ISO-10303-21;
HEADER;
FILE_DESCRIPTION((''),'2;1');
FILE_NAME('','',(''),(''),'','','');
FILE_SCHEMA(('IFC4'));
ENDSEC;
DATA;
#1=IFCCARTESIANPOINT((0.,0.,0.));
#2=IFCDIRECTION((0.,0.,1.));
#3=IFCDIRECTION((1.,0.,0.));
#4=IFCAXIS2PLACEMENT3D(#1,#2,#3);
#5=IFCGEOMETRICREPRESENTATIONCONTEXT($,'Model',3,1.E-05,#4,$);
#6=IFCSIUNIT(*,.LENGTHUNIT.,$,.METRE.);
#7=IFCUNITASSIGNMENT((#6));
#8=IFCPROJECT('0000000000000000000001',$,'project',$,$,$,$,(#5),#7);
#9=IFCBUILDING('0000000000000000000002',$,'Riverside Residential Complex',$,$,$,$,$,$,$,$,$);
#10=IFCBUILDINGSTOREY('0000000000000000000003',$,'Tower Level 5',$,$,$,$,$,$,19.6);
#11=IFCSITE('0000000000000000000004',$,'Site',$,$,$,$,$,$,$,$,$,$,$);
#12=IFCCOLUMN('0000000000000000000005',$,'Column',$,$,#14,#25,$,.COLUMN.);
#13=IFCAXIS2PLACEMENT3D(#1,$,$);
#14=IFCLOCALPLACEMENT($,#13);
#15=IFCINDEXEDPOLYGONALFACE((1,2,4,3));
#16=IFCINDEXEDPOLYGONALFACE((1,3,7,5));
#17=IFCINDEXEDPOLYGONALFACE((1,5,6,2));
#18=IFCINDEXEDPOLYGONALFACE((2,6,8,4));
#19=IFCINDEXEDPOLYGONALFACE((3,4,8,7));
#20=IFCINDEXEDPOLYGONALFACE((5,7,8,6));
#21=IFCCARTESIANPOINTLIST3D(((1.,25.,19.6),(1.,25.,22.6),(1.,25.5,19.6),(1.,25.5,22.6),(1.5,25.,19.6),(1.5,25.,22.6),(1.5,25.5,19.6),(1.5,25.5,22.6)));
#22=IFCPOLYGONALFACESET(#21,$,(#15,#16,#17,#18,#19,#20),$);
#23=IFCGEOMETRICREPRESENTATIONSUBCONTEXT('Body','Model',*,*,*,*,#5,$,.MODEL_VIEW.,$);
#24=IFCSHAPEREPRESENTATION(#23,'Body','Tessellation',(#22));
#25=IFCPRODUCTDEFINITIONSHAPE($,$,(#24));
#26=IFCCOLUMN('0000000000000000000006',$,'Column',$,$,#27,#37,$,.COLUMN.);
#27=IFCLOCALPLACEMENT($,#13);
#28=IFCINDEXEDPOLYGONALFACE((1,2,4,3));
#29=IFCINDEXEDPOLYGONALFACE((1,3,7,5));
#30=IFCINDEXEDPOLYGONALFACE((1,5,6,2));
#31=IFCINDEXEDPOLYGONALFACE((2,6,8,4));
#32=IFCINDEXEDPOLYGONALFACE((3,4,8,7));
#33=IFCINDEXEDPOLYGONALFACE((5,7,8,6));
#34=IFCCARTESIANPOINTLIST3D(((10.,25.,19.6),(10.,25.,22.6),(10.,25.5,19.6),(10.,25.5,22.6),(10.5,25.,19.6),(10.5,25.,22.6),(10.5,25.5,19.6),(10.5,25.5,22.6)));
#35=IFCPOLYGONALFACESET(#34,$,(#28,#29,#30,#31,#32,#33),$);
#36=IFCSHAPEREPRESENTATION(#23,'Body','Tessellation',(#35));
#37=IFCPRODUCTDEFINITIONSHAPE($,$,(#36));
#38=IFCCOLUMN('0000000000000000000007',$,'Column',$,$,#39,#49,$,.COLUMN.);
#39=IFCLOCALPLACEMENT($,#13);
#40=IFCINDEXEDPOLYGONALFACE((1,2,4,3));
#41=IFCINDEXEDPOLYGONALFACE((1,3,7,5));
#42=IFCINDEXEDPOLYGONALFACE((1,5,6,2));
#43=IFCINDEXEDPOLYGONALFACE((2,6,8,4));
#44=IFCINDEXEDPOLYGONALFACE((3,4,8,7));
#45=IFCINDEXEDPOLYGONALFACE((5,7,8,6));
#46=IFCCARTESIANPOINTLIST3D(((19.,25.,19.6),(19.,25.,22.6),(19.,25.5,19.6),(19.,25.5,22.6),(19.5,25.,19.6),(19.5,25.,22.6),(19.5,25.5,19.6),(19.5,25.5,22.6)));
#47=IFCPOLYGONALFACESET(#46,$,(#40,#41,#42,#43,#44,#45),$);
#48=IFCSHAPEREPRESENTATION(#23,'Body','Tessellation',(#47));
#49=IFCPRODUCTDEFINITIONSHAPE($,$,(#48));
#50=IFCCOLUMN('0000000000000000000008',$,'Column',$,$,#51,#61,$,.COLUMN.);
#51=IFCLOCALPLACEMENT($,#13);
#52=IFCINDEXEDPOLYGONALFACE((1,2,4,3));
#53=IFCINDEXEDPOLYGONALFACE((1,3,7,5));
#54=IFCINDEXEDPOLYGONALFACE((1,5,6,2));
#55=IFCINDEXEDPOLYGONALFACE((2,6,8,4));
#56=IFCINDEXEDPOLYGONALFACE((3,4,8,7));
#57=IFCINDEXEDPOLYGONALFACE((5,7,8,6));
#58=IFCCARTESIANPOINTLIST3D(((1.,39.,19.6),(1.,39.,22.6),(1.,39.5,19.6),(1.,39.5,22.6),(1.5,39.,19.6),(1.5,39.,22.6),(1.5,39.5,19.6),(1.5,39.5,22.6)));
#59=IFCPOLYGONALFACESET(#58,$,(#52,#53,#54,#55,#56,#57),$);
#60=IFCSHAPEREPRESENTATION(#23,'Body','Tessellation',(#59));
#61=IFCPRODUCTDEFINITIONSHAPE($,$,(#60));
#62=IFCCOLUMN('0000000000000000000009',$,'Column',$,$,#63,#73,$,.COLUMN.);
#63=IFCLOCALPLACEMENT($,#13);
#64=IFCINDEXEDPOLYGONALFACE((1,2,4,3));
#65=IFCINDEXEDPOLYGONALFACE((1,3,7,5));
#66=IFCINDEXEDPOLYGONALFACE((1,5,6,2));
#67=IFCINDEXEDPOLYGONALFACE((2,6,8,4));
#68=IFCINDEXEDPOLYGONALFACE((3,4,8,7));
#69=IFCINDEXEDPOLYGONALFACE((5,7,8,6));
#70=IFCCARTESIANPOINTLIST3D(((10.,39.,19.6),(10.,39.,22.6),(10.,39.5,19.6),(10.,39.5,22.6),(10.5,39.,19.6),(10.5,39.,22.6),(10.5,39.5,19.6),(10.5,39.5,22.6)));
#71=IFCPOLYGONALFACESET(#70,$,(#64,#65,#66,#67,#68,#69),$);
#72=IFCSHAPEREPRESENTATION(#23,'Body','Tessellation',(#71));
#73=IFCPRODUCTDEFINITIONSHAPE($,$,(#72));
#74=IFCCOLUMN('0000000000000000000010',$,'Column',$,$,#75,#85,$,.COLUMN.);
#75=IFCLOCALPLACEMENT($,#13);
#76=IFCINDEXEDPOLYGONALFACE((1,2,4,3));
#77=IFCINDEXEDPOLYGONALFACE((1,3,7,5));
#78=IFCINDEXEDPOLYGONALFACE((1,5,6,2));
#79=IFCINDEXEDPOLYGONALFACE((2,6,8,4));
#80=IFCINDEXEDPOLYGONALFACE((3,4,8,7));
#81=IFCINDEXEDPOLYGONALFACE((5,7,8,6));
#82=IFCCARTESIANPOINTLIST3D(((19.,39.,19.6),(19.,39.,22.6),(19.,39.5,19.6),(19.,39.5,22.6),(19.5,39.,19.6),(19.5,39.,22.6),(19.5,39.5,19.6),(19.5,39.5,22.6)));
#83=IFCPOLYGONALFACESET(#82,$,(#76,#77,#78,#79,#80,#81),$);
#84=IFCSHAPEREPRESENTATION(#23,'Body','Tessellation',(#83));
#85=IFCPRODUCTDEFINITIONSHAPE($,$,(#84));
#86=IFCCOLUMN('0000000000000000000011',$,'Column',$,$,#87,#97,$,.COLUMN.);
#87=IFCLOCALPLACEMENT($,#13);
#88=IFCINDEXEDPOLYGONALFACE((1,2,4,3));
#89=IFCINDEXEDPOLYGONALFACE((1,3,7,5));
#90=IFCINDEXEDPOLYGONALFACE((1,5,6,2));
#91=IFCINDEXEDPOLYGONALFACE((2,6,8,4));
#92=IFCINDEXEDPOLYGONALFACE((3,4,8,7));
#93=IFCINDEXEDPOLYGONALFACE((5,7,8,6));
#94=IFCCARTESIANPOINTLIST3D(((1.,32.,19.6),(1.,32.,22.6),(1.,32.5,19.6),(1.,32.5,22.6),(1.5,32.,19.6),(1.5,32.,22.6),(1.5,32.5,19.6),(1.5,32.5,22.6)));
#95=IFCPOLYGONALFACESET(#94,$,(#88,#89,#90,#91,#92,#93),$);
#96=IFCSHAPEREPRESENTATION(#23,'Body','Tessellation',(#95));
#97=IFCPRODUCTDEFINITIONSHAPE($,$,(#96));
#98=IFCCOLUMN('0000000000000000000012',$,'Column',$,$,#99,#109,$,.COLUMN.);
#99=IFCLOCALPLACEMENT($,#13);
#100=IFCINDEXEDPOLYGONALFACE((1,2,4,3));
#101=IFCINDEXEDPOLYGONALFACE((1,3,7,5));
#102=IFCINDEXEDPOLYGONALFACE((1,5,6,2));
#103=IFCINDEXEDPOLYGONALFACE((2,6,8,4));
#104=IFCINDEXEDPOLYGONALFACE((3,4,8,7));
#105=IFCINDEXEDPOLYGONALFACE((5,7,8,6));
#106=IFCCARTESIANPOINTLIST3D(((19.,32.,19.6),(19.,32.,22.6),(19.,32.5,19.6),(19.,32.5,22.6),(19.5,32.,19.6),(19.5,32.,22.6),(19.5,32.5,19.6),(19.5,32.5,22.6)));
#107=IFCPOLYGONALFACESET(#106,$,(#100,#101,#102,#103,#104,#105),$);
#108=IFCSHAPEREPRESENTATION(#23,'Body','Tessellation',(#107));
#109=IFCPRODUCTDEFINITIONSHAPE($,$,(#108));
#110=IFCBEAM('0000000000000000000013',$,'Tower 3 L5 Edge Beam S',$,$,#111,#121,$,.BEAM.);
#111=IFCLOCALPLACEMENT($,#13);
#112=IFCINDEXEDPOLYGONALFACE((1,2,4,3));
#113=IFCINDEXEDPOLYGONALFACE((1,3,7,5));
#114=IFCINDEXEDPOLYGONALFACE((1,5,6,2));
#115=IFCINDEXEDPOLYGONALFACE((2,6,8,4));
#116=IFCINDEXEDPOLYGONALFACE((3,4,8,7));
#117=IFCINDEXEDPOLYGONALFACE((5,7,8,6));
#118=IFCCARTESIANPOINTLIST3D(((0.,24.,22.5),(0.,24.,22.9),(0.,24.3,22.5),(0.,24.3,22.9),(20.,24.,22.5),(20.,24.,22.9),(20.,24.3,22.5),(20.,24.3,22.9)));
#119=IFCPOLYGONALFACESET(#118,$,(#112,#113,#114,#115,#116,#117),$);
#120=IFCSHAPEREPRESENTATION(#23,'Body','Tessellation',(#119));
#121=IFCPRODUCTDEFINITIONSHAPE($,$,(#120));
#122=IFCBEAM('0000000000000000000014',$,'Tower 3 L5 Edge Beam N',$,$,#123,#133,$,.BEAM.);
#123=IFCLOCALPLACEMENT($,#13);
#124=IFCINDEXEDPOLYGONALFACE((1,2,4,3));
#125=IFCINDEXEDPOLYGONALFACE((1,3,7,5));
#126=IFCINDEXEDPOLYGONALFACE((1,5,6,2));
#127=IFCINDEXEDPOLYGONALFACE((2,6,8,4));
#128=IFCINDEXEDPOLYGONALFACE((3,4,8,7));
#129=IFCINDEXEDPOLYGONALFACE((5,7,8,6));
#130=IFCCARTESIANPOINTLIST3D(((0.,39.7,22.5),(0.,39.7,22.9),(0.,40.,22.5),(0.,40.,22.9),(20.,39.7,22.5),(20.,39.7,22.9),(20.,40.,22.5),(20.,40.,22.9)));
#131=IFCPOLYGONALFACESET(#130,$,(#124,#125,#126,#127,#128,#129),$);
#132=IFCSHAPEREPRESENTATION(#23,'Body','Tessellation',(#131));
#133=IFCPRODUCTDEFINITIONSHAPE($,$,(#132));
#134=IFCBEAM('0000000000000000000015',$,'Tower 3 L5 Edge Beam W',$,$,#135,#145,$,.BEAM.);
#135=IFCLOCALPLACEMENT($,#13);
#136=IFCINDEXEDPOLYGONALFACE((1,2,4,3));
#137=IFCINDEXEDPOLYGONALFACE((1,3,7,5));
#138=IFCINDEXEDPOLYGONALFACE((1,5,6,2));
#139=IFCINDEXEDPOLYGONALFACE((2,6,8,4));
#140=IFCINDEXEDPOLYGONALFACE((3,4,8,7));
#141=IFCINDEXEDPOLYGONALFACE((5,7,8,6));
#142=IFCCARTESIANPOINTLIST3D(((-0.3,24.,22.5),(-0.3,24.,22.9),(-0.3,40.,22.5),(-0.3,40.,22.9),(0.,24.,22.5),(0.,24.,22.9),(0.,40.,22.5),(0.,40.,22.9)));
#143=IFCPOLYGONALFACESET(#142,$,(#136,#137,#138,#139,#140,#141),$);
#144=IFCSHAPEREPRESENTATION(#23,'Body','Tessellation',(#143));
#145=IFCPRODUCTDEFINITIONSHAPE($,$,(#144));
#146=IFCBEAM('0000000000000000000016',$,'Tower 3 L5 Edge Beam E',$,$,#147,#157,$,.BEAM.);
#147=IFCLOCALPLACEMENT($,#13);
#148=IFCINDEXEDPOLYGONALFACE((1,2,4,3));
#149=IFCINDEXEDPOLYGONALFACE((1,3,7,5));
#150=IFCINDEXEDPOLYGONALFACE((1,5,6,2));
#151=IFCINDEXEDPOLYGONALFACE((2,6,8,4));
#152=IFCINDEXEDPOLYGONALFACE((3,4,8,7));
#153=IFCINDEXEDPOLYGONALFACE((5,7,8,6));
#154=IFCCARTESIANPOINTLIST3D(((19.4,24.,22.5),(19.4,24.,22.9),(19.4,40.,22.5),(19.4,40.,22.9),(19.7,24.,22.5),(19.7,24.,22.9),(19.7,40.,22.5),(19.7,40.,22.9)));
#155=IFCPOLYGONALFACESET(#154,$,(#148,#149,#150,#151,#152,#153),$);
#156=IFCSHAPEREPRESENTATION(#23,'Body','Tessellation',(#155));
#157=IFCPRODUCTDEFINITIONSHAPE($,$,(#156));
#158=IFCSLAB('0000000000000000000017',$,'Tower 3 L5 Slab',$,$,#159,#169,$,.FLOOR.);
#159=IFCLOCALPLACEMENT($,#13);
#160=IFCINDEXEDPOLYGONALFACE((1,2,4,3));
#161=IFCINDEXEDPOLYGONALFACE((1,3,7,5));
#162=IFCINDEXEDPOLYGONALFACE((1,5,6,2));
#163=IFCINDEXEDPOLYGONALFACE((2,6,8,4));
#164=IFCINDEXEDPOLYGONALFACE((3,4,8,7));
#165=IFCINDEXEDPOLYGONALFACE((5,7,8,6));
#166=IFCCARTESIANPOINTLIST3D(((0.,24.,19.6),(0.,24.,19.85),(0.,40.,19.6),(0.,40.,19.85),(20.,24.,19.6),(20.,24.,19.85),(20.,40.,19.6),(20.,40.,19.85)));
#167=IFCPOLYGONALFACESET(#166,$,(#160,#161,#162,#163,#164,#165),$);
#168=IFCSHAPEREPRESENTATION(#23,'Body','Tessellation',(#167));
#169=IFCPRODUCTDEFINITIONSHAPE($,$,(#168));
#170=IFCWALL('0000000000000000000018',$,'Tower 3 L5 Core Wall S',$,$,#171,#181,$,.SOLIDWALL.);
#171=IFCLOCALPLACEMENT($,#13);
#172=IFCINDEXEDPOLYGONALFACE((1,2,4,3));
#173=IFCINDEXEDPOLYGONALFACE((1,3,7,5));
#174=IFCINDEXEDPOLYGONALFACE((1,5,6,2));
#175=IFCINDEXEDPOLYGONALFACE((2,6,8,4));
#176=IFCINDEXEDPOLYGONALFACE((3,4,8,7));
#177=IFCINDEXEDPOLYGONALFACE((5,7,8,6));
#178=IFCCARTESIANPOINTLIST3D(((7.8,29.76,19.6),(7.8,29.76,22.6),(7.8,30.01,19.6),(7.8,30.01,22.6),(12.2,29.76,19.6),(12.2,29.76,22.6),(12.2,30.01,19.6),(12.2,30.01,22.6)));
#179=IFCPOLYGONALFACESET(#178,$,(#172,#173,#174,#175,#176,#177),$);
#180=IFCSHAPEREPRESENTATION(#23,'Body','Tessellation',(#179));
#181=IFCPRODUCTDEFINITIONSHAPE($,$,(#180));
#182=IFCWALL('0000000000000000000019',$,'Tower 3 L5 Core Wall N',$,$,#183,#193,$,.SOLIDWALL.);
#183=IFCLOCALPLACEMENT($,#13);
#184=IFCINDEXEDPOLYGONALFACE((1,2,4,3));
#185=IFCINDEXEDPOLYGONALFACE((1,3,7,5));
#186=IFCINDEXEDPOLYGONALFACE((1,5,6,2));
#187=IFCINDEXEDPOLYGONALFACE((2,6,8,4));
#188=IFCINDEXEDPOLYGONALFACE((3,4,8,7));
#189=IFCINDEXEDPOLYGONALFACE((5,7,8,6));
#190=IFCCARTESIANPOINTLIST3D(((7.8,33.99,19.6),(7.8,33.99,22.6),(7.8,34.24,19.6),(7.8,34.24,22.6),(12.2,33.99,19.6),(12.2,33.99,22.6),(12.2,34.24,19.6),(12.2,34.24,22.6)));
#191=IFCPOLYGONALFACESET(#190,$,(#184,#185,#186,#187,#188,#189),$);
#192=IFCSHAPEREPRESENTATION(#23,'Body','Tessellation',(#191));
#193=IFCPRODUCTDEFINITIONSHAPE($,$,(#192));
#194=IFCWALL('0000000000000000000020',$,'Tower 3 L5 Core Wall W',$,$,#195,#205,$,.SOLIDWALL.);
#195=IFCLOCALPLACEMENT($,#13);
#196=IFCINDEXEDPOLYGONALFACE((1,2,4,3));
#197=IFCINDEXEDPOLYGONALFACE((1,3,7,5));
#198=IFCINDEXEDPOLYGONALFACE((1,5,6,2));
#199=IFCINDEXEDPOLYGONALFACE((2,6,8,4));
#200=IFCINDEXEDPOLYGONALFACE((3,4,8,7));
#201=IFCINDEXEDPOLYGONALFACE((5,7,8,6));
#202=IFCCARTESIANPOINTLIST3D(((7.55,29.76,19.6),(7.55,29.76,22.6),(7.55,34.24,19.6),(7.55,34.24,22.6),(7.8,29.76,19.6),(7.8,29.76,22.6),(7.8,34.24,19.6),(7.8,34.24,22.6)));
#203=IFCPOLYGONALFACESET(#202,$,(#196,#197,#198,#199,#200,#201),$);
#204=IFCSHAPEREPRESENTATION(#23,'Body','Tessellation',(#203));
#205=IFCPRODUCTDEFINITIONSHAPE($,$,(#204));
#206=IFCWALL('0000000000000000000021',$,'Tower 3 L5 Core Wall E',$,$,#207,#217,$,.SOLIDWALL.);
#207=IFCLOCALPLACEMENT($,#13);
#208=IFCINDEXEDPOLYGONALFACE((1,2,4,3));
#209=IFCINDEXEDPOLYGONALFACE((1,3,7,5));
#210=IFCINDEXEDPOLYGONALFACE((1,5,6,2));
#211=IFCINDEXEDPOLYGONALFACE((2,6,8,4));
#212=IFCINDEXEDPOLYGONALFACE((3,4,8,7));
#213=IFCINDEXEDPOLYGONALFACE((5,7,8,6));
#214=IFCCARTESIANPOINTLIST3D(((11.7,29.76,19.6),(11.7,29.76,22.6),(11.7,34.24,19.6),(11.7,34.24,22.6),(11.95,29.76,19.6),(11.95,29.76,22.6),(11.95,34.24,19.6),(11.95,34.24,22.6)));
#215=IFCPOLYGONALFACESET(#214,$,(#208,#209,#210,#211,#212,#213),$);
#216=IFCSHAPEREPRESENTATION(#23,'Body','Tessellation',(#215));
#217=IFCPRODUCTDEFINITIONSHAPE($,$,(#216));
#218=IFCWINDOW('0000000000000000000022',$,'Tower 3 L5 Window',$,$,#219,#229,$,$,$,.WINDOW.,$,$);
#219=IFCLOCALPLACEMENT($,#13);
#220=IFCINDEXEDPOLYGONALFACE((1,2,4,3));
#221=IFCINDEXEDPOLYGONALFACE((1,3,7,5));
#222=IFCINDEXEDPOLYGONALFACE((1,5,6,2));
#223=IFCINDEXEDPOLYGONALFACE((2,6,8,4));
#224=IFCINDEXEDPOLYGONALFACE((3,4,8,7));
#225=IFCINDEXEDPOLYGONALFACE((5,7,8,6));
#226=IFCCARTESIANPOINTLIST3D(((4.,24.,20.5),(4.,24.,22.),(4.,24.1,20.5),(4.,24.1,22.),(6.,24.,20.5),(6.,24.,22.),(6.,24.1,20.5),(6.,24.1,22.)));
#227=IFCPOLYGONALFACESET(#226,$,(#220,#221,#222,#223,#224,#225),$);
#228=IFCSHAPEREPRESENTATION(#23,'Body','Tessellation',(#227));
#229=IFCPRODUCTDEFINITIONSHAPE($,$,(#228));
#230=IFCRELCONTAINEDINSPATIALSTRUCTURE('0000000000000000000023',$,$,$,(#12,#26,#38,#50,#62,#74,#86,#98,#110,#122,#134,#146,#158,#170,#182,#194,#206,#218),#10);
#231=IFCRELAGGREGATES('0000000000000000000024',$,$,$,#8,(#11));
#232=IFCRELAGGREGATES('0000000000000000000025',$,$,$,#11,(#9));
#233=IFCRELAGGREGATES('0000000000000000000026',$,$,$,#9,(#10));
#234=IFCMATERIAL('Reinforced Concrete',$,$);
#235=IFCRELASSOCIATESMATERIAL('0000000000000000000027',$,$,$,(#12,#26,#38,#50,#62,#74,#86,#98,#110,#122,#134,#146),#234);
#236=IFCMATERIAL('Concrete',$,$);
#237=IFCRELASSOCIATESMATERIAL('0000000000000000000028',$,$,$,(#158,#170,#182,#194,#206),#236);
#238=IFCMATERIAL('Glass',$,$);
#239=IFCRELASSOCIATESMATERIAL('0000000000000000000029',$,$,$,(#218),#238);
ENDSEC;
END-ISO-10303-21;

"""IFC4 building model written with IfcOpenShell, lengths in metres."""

from ifc_helpers import new_model, si_unit, frame, origin_with_axes, place, context, subcontext, project, spatial, line, indexed_curve, outline, extrude, material, element, save


model = new_model("IFC4")

# Units and contexts
model_context = context("Model", 3, precision=1e-05, world=origin_with_axes())
body_context = subcontext(model_context, "Body", "Model", "MODEL_VIEW")
ifc_project = project(units=[si_unit("LENGTHUNIT", "METRE")], contexts=[model_context])

# Site, building, storey
site = spatial("IfcSite", under=ifc_project, Name="Site")
building = spatial("IfcBuilding", under=site, Name="Riverside Residential Complex")
storey = spatial("IfcBuildingStorey", under=building, Name="Tower Level 5", Elevation=19.6)

# Columns
ifc_material_1 = material(Name="Reinforced Concrete")
for number, where, z_axis, x_axis, name in (
    (1, (1.0, 25.0, 19.6), (0.0, 0.0, 1.0), (1.0, 0.0, 0.0), "Column"),
    (2, (10.0, 25.0, 19.6), (0.0, 0.0, 1.0), (1.0, 0.0, 0.0), "Column"),
    (3, (19.0, 25.0, 19.6), (0.0, 0.0, 1.0), (1.0, 0.0, 0.0), "Column"),
    (4, (1.0, 39.0, 19.6), (0.0, 0.0, 1.0), (1.0, 0.0, 0.0), "Column"),
    (5, (10.0, 39.0, 19.6), (0.0, 0.0, 1.0), (1.0, 0.0, 0.0), "Column"),
    (6, (19.0, 39.0, 19.6), (0.0, 0.0, 1.0), (1.0, 0.0, 0.0), "Column"),
    (7, (1.0, 32.0, 19.6), (0.0, 0.0, 1.0), (1.0, 0.0, 0.0), "Column"),
    (8, (19.0, 32.0, 19.6), (0.0, 0.0, 1.0), (1.0, 0.0, 0.0), "Column"),
):
    element("IfcColumn", number, at=place(None, frame(where, z_axis=z_axis, x_axis=x_axis)), inside=storey, material=ifc_material_1, Name=name, PredefinedType="COLUMN", context=body_context, shape_type="SweptSolid", body=[
        extrude(outline(indexed_curve([(0.0, 0.0), (0.5, 0.0), (0.5, 0.5), (0.0, 0.5)], segments=[line(1, 2, 3, 4, 1)])), origin_with_axes(), (0.0, 0.0, 1.0), 3.0),
    ])

# Beams
for number, where, z_axis, x_axis, name in (
    (9, (0.0, 24.0, 22.5), (0.0, 0.0, 1.0), (1.0, 0.0, 0.0), "Tower 3 L5 Edge Beam S"),
    (10, (0.0, 39.7, 22.5), (0.0, 0.0, 1.0), (1.0, 0.0, 0.0), "Tower 3 L5 Edge Beam N"),
):
    element("IfcBeam", number, at=place(None, frame(where, z_axis=z_axis, x_axis=x_axis)), inside=storey, material=ifc_material_1, Name=name, PredefinedType="BEAM", context=body_context, shape_type="SweptSolid", body=[
        extrude(outline(indexed_curve([(0.0, 0.0), (20.0, 0.0), (20.0, 0.3), (0.0, 0.3)], segments=[line(1, 2, 3, 4, 1)])), origin_with_axes(), (0.0, 0.0, 1.0), 0.4),
    ])
for number, where, z_axis, x_axis, name in (
    (11, (0.0, 24.0, 22.5), (0.0, 0.0, 1.0), (0.0, 1.0, 0.0), "Tower 3 L5 Edge Beam W"),
    (12, (19.7, 24.0, 22.5), (0.0, 0.0, 1.0), (0.0, 1.0, 0.0), "Tower 3 L5 Edge Beam E"),
):
    element("IfcBeam", number, at=place(None, frame(where, z_axis=z_axis, x_axis=x_axis)), inside=storey, material=ifc_material_1, Name=name, PredefinedType="BEAM", context=body_context, shape_type="SweptSolid", body=[
        extrude(outline(indexed_curve([(0.0, 0.0), (16.0, 0.0), (16.0, 0.3), (0.0, 0.3)], segments=[line(1, 2, 3, 4, 1)])), origin_with_axes(), (0.0, 0.0, 1.0), 0.4),
    ])

# Slab
ifc_material_2 = material(Name="Concrete")
slab_placement = place(None, frame((0.0, 24.0, 19.6), z_axis=(0.0, 0.0, 1.0), x_axis=(1.0, 0.0, 0.0)))
element("IfcSlab", 13, at=slab_placement, inside=storey, material=ifc_material_2, Name="Tower 3 L5 Slab", PredefinedType="FLOOR", context=body_context, shape_type="SweptSolid", body=[
    extrude(outline(indexed_curve([(0.0, 0.0), (20.0, 0.0), (20.0, 16.0), (0.0, 16.0)], segments=[line(1, 2, 3, 4, 1)])), origin_with_axes(), (0.0, 0.0, 1.0), 0.25),
])

# Walls
for number, where, z_axis, x_axis, name in (
    (14, (7.8, 29.76, 19.6), (0.0, 0.0, 1.0), (1.0, 0.0, 0.0), "Tower 3 L5 Core Wall S"),
    (15, (7.8, 33.99, 19.6), (0.0, 0.0, 1.0), (1.0, 0.0, 0.0), "Tower 3 L5 Core Wall N"),
):
    element("IfcWall", number, at=place(None, frame(where, z_axis=z_axis, x_axis=x_axis)), inside=storey, material=ifc_material_2, Name=name, PredefinedType="SOLIDWALL", context=body_context, shape_type="SweptSolid", body=[
        extrude(outline(indexed_curve([(0.0, 0.0), (4.4, 0.0), (4.4, 0.25), (0.0, 0.25)], segments=[line(1, 2, 3, 4, 1)])), origin_with_axes(), (0.0, 0.0, 1.0), 3.0),
    ])
for number, where, z_axis, x_axis, name in (
    (16, (7.8, 29.76, 19.6), (0.0, 0.0, 1.0), (0.0, 1.0, 0.0), "Tower 3 L5 Core Wall W"),
    (17, (11.95, 29.76, 19.6), (0.0, 0.0, 1.0), (0.0, 1.0, 0.0), "Tower 3 L5 Core Wall E"),
):
    element("IfcWall", number, at=place(None, frame(where, z_axis=z_axis, x_axis=x_axis)), inside=storey, material=ifc_material_2, Name=name, PredefinedType="SOLIDWALL", context=body_context, shape_type="SweptSolid", body=[
        extrude(outline(indexed_curve([(0.0, 0.0), (4.48, 0.0), (4.48, 0.25), (0.0, 0.25)], segments=[line(1, 2, 3, 4, 1)])), origin_with_axes(), (0.0, 0.0, 1.0), 3.0),
    ])

# Window
ifc_material_3 = material(Name="Glass")
for number, where, z_axis, x_axis, name in (
    (18, (4.0, 24.0, 20.5), (0.0, 0.0, 1.0), (1.0, 0.0, 0.0), "Tower 3 L5 Window"),
):
    element("IfcWindow", number, at=place(None, frame(where, z_axis=z_axis, x_axis=x_axis)), inside=storey, material=ifc_material_3, Name=name, PredefinedType="WINDOW", context=body_context, shape_type="SweptSolid", body=[
        extrude(outline(indexed_curve([(0.0, 0.0), (2.0, 0.0), (2.0, 0.1), (0.0, 0.1)], segments=[line(1, 2, 3, 4, 1)])), origin_with_axes(), (0.0, 0.0, 1.0), 1.5),
    ])

save(model, "model.ifc")
